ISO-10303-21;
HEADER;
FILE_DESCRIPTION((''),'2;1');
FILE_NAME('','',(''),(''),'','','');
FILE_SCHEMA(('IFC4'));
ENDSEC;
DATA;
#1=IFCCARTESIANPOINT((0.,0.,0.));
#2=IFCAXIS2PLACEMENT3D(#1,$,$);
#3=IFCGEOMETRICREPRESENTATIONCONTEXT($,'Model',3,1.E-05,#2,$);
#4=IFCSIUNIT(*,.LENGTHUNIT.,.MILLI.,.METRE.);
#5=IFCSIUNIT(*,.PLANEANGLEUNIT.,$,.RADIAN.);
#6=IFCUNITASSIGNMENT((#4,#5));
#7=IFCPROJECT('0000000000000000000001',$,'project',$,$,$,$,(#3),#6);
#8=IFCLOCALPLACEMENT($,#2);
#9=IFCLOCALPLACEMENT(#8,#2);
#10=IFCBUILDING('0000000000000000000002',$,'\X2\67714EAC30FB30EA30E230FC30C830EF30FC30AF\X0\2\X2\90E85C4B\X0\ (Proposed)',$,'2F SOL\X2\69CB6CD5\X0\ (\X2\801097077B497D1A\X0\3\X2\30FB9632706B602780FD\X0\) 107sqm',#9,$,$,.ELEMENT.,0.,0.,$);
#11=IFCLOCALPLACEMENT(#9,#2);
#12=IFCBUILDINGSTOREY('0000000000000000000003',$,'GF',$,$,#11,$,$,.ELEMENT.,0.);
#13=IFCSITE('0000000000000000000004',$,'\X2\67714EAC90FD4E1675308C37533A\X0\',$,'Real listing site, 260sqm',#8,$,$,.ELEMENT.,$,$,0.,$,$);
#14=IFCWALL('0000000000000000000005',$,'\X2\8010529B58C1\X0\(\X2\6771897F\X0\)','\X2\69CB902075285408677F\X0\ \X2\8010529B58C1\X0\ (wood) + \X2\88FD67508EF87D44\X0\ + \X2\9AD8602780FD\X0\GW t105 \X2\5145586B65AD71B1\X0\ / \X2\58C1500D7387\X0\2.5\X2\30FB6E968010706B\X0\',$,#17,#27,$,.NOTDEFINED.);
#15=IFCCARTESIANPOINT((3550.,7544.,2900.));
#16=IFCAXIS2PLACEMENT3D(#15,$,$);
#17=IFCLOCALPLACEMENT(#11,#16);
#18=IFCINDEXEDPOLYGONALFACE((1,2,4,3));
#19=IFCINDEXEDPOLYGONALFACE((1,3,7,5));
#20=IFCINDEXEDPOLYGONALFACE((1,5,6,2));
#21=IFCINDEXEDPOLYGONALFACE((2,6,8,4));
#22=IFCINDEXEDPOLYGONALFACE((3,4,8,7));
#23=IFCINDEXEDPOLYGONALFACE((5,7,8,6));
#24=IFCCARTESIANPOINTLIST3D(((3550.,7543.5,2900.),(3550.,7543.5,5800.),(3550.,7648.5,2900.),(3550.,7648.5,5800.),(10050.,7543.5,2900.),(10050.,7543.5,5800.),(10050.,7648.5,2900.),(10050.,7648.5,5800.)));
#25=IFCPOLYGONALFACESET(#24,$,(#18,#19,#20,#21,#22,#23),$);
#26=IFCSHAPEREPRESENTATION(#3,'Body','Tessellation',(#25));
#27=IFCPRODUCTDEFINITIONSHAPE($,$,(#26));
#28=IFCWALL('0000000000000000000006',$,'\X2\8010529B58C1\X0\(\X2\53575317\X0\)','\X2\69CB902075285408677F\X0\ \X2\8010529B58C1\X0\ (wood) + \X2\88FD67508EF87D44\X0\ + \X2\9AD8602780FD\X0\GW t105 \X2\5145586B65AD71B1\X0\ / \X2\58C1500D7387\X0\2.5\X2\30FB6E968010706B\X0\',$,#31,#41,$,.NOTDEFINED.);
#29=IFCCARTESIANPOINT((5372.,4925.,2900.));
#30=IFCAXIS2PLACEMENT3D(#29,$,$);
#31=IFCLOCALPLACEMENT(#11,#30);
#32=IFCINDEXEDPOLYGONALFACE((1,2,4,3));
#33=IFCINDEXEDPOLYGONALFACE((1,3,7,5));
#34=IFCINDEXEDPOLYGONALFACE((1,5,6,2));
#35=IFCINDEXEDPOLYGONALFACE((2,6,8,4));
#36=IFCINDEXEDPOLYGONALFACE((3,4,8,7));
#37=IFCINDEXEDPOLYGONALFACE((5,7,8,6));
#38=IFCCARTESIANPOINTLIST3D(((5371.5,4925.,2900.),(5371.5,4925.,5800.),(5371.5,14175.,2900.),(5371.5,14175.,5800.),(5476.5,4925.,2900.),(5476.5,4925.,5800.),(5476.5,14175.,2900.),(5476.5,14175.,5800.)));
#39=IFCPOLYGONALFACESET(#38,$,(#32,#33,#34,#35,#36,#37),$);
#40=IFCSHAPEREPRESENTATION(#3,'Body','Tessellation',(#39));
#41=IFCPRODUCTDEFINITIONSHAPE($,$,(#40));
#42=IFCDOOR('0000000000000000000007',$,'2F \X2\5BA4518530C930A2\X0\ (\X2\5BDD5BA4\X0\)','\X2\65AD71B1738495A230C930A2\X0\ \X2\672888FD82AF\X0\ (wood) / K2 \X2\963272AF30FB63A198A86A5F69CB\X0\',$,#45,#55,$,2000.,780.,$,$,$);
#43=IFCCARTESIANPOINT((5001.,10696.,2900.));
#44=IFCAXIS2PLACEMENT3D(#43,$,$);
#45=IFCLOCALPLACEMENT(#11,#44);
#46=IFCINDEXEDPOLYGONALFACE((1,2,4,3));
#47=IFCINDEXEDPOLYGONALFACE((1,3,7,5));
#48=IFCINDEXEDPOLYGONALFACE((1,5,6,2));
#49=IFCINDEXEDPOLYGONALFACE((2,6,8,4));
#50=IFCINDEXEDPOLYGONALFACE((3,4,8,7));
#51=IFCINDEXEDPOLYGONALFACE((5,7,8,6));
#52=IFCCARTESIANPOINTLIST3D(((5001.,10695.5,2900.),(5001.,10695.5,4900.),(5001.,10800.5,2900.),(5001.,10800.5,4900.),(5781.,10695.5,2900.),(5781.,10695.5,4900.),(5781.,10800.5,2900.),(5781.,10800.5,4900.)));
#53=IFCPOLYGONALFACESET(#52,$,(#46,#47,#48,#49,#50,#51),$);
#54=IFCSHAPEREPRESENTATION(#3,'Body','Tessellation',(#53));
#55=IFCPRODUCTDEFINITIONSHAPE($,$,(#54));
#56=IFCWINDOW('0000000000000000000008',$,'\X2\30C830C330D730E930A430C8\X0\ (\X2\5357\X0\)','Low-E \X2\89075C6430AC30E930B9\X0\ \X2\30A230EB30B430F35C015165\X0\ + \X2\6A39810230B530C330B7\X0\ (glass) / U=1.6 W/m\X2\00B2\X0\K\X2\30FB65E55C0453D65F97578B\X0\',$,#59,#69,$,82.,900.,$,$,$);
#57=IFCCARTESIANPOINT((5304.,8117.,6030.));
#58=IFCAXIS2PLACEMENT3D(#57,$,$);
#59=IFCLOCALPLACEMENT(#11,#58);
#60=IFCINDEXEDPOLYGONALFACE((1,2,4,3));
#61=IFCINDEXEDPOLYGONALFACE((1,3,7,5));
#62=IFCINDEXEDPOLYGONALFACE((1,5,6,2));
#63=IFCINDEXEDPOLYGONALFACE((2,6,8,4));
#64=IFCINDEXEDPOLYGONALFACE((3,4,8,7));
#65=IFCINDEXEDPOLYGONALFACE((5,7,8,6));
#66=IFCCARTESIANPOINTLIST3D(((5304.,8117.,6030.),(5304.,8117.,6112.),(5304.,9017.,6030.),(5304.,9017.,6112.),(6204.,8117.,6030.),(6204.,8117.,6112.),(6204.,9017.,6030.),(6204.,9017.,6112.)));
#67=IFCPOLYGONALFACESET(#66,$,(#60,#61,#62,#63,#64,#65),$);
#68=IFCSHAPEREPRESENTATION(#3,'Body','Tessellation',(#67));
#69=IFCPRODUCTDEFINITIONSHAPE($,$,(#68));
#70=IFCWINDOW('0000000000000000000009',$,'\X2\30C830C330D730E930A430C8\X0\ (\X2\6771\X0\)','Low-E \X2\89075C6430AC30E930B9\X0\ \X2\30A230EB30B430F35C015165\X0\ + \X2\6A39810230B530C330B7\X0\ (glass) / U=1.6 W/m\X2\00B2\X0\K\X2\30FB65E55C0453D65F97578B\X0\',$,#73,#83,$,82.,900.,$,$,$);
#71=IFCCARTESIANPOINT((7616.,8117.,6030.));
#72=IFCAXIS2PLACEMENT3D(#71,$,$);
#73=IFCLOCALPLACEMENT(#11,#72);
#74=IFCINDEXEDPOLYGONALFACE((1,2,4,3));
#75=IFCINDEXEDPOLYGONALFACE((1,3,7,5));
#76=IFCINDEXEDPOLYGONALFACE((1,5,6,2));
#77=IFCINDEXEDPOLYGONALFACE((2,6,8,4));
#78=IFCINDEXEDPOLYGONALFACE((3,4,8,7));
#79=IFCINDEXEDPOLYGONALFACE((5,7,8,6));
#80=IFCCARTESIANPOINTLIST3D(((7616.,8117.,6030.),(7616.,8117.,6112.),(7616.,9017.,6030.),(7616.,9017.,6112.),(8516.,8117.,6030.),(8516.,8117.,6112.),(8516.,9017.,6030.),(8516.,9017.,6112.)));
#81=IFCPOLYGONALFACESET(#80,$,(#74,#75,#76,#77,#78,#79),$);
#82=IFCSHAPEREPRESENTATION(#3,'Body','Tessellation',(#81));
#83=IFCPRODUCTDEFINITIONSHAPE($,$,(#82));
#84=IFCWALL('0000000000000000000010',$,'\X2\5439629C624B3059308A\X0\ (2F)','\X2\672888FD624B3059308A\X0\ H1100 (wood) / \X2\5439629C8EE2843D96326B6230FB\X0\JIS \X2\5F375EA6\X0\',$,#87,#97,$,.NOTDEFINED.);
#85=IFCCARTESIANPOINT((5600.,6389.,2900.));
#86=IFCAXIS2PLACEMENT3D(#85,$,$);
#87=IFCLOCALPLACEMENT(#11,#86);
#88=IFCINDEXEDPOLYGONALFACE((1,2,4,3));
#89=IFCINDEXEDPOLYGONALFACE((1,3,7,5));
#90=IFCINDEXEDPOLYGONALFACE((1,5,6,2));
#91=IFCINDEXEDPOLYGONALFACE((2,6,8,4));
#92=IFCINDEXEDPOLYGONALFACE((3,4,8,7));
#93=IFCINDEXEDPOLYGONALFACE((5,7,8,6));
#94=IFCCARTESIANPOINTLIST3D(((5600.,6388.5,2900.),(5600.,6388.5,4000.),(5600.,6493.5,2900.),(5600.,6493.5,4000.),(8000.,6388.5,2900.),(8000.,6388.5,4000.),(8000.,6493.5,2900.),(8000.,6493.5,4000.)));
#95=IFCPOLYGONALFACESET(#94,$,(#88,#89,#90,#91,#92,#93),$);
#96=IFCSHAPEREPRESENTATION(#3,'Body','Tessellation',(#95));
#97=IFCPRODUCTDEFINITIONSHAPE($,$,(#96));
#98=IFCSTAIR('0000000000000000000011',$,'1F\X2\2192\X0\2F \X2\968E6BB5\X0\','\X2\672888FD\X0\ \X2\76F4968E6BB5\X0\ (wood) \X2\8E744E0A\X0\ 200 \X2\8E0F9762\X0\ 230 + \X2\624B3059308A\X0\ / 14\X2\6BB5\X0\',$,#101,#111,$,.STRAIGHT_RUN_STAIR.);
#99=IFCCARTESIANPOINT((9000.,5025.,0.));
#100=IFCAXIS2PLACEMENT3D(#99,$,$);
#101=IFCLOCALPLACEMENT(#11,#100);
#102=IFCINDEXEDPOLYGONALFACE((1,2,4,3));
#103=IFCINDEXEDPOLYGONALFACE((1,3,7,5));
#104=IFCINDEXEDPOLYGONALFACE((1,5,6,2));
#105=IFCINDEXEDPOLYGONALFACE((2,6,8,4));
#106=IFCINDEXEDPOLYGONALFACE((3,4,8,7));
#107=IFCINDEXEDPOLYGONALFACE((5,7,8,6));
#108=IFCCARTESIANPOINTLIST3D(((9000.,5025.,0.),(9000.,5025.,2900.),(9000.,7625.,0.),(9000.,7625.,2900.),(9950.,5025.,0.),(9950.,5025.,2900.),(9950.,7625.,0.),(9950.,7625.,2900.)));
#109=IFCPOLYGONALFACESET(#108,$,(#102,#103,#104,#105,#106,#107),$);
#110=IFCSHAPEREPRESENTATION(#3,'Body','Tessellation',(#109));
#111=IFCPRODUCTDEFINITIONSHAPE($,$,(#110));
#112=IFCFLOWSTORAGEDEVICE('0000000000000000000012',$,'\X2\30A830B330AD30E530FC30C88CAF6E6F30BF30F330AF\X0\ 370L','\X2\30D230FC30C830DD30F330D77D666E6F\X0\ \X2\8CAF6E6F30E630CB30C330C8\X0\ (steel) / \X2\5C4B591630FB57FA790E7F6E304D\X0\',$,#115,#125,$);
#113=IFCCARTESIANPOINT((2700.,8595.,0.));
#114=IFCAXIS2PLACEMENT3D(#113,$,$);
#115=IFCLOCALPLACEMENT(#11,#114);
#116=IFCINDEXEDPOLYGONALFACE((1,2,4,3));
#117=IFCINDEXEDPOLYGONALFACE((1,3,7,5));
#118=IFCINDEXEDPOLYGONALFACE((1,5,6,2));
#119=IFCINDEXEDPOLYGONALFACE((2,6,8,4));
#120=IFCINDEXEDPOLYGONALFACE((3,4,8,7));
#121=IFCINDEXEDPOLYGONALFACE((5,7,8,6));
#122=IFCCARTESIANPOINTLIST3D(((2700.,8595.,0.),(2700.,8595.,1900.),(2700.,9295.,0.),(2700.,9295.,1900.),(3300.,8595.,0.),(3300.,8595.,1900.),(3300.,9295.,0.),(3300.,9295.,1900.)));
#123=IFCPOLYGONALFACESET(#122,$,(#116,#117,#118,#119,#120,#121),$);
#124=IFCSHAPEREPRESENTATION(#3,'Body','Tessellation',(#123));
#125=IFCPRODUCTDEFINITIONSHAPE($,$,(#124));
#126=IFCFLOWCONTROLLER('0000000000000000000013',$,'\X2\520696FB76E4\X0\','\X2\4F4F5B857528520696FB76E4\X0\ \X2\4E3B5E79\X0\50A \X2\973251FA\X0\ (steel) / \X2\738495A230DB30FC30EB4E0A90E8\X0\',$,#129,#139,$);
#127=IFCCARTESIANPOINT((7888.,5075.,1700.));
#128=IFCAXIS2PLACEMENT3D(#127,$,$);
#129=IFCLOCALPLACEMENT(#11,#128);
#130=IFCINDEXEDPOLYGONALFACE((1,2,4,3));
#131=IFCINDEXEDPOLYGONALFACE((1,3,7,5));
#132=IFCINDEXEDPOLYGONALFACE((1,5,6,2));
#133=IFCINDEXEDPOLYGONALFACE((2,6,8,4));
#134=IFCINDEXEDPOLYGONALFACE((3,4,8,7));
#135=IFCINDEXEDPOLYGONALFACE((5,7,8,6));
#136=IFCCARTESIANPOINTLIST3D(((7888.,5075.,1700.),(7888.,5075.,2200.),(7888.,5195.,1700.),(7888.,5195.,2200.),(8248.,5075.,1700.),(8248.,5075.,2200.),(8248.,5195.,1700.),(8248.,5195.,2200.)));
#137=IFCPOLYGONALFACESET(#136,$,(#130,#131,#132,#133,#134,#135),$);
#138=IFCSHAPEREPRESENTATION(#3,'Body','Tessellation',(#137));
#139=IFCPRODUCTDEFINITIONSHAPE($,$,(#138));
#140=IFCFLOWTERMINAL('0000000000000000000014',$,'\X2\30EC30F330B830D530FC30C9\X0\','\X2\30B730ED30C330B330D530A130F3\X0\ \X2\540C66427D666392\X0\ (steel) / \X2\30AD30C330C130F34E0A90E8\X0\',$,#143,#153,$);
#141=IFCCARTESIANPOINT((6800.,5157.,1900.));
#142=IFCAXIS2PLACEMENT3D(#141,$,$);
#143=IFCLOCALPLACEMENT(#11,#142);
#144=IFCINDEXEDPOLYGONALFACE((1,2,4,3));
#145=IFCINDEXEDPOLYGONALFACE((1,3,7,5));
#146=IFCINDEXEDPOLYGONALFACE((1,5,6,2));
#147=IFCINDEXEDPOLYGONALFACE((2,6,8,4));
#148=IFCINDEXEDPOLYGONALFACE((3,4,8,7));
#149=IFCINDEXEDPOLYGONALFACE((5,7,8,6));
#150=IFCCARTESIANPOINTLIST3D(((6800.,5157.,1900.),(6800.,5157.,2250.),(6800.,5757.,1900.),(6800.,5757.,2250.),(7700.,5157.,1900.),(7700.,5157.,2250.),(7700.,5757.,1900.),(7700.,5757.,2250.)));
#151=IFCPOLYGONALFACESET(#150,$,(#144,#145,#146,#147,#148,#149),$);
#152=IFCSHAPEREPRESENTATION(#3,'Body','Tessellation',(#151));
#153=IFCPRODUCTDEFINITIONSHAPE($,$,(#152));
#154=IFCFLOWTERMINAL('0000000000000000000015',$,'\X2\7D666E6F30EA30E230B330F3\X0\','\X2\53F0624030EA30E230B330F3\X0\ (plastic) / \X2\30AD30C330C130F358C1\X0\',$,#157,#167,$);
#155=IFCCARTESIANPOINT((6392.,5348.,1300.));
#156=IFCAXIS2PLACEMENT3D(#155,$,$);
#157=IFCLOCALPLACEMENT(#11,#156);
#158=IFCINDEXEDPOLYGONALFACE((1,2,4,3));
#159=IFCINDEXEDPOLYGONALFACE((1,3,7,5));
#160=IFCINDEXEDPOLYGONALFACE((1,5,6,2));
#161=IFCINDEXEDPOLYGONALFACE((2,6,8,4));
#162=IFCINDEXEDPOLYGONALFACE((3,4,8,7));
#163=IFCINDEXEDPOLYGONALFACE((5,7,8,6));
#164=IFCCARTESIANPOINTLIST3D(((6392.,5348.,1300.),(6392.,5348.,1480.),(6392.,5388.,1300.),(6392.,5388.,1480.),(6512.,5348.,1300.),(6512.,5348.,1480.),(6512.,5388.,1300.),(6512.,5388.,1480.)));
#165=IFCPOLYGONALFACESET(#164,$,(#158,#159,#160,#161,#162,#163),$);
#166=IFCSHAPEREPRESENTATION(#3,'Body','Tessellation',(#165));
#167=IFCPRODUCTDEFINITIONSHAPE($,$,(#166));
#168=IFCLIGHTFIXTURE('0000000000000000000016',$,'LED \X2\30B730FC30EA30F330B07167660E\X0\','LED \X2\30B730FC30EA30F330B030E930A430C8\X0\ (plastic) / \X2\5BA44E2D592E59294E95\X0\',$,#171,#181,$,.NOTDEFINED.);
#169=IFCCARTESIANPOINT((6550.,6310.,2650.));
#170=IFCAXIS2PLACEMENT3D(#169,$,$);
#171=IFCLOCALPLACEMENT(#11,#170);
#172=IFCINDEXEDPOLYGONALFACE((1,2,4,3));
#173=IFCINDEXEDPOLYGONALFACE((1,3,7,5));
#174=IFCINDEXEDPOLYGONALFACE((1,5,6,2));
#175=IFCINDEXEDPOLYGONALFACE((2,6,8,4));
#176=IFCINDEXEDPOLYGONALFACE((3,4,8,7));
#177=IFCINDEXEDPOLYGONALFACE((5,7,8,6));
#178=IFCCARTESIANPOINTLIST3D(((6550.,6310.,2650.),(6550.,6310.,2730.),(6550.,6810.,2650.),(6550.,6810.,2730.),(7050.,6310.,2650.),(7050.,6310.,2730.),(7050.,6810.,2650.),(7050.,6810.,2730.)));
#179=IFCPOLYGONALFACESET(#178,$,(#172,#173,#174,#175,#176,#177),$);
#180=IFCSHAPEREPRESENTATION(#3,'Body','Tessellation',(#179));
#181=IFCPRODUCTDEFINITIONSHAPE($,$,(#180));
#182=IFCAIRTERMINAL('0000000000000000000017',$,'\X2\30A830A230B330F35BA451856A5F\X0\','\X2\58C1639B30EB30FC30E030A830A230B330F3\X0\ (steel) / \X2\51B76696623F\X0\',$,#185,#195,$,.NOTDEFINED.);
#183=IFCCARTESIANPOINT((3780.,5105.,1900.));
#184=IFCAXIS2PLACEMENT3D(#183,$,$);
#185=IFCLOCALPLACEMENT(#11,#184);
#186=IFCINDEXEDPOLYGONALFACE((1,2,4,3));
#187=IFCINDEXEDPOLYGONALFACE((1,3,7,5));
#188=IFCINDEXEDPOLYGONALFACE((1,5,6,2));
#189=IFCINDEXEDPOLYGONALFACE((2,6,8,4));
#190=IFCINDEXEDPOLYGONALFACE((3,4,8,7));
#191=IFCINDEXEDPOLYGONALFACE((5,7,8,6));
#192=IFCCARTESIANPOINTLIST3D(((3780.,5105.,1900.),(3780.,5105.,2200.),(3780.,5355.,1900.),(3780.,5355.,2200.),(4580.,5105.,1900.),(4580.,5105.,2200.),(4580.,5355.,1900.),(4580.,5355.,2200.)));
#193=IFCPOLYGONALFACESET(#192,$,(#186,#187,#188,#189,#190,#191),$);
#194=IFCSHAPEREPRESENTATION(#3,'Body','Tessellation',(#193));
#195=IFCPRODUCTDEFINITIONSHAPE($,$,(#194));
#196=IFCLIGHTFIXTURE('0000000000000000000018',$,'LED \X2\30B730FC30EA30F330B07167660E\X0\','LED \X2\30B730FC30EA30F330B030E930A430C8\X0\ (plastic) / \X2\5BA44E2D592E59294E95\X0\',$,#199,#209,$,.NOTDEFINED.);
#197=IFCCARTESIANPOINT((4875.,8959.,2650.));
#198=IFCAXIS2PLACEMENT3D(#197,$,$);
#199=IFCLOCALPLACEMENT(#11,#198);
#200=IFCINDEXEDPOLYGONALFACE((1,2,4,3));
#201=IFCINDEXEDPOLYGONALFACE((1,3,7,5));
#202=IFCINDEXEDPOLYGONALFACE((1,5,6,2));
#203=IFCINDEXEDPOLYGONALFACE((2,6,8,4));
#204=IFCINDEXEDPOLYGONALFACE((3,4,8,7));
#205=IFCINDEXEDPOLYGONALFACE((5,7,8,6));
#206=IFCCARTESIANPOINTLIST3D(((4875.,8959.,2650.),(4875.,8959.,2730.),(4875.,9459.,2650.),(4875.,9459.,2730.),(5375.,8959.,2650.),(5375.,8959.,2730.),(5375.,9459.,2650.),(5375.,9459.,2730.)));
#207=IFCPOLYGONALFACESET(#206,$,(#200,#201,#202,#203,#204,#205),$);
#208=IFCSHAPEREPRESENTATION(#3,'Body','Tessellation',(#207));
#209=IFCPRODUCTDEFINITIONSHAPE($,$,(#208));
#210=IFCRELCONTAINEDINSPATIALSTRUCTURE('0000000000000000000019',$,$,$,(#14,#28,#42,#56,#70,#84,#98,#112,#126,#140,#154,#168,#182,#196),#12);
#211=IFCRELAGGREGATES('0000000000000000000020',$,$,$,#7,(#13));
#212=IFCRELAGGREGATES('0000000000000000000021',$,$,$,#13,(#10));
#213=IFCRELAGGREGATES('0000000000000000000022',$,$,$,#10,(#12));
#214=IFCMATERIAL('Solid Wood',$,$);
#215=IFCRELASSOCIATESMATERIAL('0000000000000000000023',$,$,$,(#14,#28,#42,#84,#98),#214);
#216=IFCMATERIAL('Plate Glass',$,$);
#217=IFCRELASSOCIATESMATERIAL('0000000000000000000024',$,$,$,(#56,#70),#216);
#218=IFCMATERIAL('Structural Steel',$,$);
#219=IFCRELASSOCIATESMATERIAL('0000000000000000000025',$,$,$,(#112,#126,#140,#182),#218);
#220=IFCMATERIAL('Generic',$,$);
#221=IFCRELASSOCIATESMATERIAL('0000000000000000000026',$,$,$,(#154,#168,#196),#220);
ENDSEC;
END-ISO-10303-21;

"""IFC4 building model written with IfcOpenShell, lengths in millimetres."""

from ifc_helpers import new_model, si_unit, frame, frame_2d, origin, place, context, project, spatial, rectangle, extrude, material, element, fill, save


model = new_model("IFC4")

# Units and contexts
model_context = context("Model", 3, precision=1e-05, world=origin())
ifc_project = project(units=[si_unit("LENGTHUNIT", "METRE", prefix="MILLI"), si_unit("PLANEANGLEUNIT", "RADIAN")], contexts=[model_context])

# Site, building, storey
site_placement = place(None, origin())
site = spatial("IfcSite", under=ifc_project, at=site_placement, Name="東京都世田谷区", ObjectType="Real listing site, 260sqm", CompositionType="ELEMENT", RefElevation=0.0)
building_placement = place(site_placement, origin())
building = spatial("IfcBuilding", under=site, at=building_placement, Name="東京・リモートワーク2部屋 (Proposed)", ObjectType="2F SOL構法 (耐震等級3・防火性能) 107sqm", CompositionType="ELEMENT", ElevationOfRefHeight=0.0, ElevationOfTerrain=0.0)
storey_placement = place(building_placement, origin())
storey = spatial("IfcBuildingStorey", under=building, at=storey_placement, Name="GF", CompositionType="ELEMENT", Elevation=0.0)

# Shared definitions
ifc_material_1 = material(Name="Solid Wood")

# Wall
wall_1_placement = place(storey_placement, frame((3550.0, 7544.0, 2900.0)))
element("IfcWall", 1, at=wall_1_placement, inside=storey, material=ifc_material_1, Name="耐力壁(東西)", Description="構造用合板 耐力壁 (wood) + 製材軸組 + 高性能GW t105 充填断熱 / 壁倍率2.5・準耐火", PredefinedType="NOTDEFINED", context=model_context, shape_type="SweptSolid", body=[
    extrude(rectangle(XDim=6500.0, YDim=105.0, at=frame_2d((3250.0, 52.0))), frame((3550.0, 7544.0, 2900.0)), (0.0, 0.0, 1.0), 2900.0),
])

# Wall, opening, door
wall_2_placement = place(storey_placement, frame((5372.0, 4925.0, 2900.0)))
wall_2 = element("IfcWall", 2, at=wall_2_placement, inside=storey, material=ifc_material_1, Name="耐力壁(南北)", Description="構造用合板 耐力壁 (wood) + 製材軸組 + 高性能GW t105 充填断熱 / 壁倍率2.5・準耐火", PredefinedType="NOTDEFINED", context=model_context, shape_type="SweptSolid", body=[
    extrude(rectangle(XDim=105.0, YDim=9250.0, at=frame_2d((52.0, 4625.0))), frame((5372.0, 4925.0, 2900.0)), (0.0, 0.0, 1.0), 2900.0),
])
opening_placement = place(storey_placement, frame((5001.0, 10696.0, 2900.0)))
opening = element("IfcOpeningElement", 3, at=opening_placement, cuts=wall_2, PredefinedType="NOTDEFINED", context=model_context, shape_type="SweptSolid", body=[
    extrude(rectangle(XDim=780.0, YDim=105.0, at=frame_2d((390.0, 52.0))), frame((5001.0, 10696.0, 2900.0)), (0.0, 0.0, 1.0), 2000.0),
])
door_placement = place(storey_placement, frame((5001.0, 10696.0, 2900.0)))
door = element("IfcDoor", 4, at=door_placement, inside=storey, material=ifc_material_1, Name="2F 室内ドア (寝室)", Description="断熱玄関ドア 木製芯 (wood) / K2 防犯・採風機構", OverallHeight=2000.0, OverallWidth=780.0, context=model_context, shape_type="SweptSolid", body=[
    extrude(rectangle(XDim=780.0, YDim=105.0, at=frame_2d((390.0, 52.0))), frame((5001.0, 10696.0, 2900.0)), (0.0, 0.0, 1.0), 2000.0),
])
fill(opening, door)

# Windows
ifc_material_2 = material(Name="Plate Glass")
window_1_placement = place(storey_placement, frame((5304.0, 8117.0, 6030.0)))
element("IfcWindow", 5, at=window_1_placement, inside=storey, material=ifc_material_2, Name="トップライト (南)", Description="Low-E 複層ガラス アルゴン封入 + 樹脂サッシ (glass) / U=1.6 W/m²K・日射取得型", OverallHeight=82.0, OverallWidth=900.0, context=model_context, shape_type="SweptSolid", body=[
    extrude(rectangle(XDim=900.0, YDim=900.0, at=frame_2d((450.0, 450.0))), frame((5304.0, 8117.0, 6030.0)), (0.0, 0.0, 1.0), 82.0),
])
window_2_placement = place(storey_placement, frame((7616.0, 8117.0, 6030.0)))
element("IfcWindow", 6, at=window_2_placement, inside=storey, material=ifc_material_2, Name="トップライト (東)", Description="Low-E 複層ガラス アルゴン封入 + 樹脂サッシ (glass) / U=1.6 W/m²K・日射取得型", OverallHeight=82.0, OverallWidth=900.0, context=model_context, shape_type="SweptSolid", body=[
    extrude(rectangle(XDim=900.0, YDim=900.0, at=frame_2d((450.0, 450.0))), frame((7616.0, 8117.0, 6030.0)), (0.0, 0.0, 1.0), 82.0),
])

# Wall
wall_3_placement = place(storey_placement, frame((5600.0, 6389.0, 2900.0)))
element("IfcWall", 7, at=wall_3_placement, inside=storey, material=ifc_material_1, Name="吹抜手すり (2F)", Description="木製手すり H1100 (wood) / 吹抜転落防止・JIS 強度", PredefinedType="NOTDEFINED", context=model_context, shape_type="SweptSolid", body=[
    extrude(rectangle(XDim=2400.0, YDim=105.0, at=frame_2d((1200.0, 52.0))), frame((5600.0, 6389.0, 2900.0)), (0.0, 0.0, 1.0), 1100.0),
])

# Stair
stair_placement = place(storey_placement, frame((9000.0, 5025.0, 0.0)))
element("IfcStair", 8, at=stair_placement, inside=storey, material=ifc_material_1, Name="1F→2F 階段", Description="木製 直階段 (wood) 蹴上 200 踏面 230 + 手すり / 14段", PredefinedType="STRAIGHT_RUN_STAIR", context=model_context, shape_type="SweptSolid", body=[
    extrude(rectangle(XDim=950.0, YDim=2600.0, at=frame_2d((475.0, 1300.0))), frame((9000.0, 5025.0, 0.0)), (0.0, 0.0, 1.0), 2900.0),
])

# Flow storage device
ifc_material_3 = material(Name="Structural Steel")
flow_storage_device_placement = place(storey_placement, frame((2700.0, 8595.0, 0.0)))
element("IfcFlowStorageDevice", 9, at=flow_storage_device_placement, inside=storey, material=ifc_material_3, Name="エコキュート貯湯タンク 370L", Description="ヒートポンプ給湯 貯湯ユニット (steel) / 屋外・基礎置き", context=model_context, shape_type="SweptSolid", body=[
    extrude(rectangle(XDim=600.0, YDim=700.0, at=frame_2d((300.0, 350.0))), frame((2700.0, 8595.0, 0.0)), (0.0, 0.0, 1.0), 1900.0),
])

# Flow controller
flow_controller_placement = place(storey_placement, frame((7888.0, 5075.0, 1700.0)))
element("IfcFlowController", 10, at=flow_controller_placement, inside=storey, material=ifc_material_3, Name="分電盤", Description="住宅用分電盤 主幹50A 露出 (steel) / 玄関ホール上部", context=model_context, shape_type="SweptSolid", body=[
    extrude(rectangle(XDim=360.0, YDim=120.0, at=frame_2d((180.0, 60.0))), frame((7888.0, 5075.0, 1700.0)), (0.0, 0.0, 1.0), 500.0),
])

# Flow terminals
flow_terminal_1_placement = place(storey_placement, frame((6800.0, 5157.0, 1900.0)))
element("IfcFlowTerminal", 11, at=flow_terminal_1_placement, inside=storey, material=ifc_material_3, Name="レンジフード", Description="シロッコファン 同時給排 (steel) / キッチン上部", context=model_context, shape_type="SweptSolid", body=[
    extrude(rectangle(XDim=900.0, YDim=600.0, at=frame_2d((450.0, 300.0))), frame((6800.0, 5157.0, 1900.0)), (0.0, 0.0, 1.0), 350.0),
])
ifc_material_4 = material(Name="Generic")
flow_terminal_2_placement = place(storey_placement, frame((6392.0, 5348.0, 1300.0)))
element("IfcFlowTerminal", 12, at=flow_terminal_2_placement, inside=storey, material=ifc_material_4, Name="給湯リモコン", Description="台所リモコン (plastic) / キッチン壁", context=model_context, shape_type="SweptSolid", body=[
    extrude(rectangle(XDim=120.0, YDim=40.0, at=frame_2d((60.0, 20.0))), frame((6392.0, 5348.0, 1300.0)), (0.0, 0.0, 1.0), 180.0),
])

# Light fixture
light_fixture_1_placement = place(storey_placement, frame((6550.0, 6310.0, 2650.0)))
element("IfcLightFixture", 13, at=light_fixture_1_placement, inside=storey, material=ifc_material_4, Name="LED シーリング照明", Description="LED シーリングライト (plastic) / 室中央天井", PredefinedType="NOTDEFINED", context=model_context, shape_type="SweptSolid", body=[
    extrude(rectangle(XDim=500.0, YDim=500.0, at=frame_2d((250.0, 250.0))), frame((6550.0, 6310.0, 2650.0)), (0.0, 0.0, 1.0), 80.0),
])

# Air terminal
air_terminal_1_placement = place(storey_placement, frame((3780.0, 5105.0, 1900.0)))
element("IfcAirTerminal", 14, at=air_terminal_1_placement, inside=storey, material=ifc_material_3, Name="エアコン室内機", Description="壁掛ルームエアコン (steel) / 冷暖房", PredefinedType="NOTDEFINED", context=model_context, shape_type="SweptSolid", body=[
    extrude(rectangle(XDim=800.0, YDim=250.0, at=frame_2d((400.0, 125.0))), frame((3780.0, 5105.0, 1900.0)), (0.0, 0.0, 1.0), 300.0),
])

# Light fixture
light_fixture_2_placement = place(storey_placement, frame((4875.0, 8959.0, 2650.0)))
element("IfcLightFixture", 15, at=light_fixture_2_placement, inside=storey, material=ifc_material_4, Name="LED シーリング照明", Description="LED シーリングライト (plastic) / 室中央天井", PredefinedType="NOTDEFINED", context=model_context, shape_type="SweptSolid", body=[
    extrude(rectangle(XDim=500.0, YDim=500.0, at=frame_2d((250.0, 250.0))), frame((4875.0, 8959.0, 2650.0)), (0.0, 0.0, 1.0), 80.0),
])

save(model, "model.ifc")
